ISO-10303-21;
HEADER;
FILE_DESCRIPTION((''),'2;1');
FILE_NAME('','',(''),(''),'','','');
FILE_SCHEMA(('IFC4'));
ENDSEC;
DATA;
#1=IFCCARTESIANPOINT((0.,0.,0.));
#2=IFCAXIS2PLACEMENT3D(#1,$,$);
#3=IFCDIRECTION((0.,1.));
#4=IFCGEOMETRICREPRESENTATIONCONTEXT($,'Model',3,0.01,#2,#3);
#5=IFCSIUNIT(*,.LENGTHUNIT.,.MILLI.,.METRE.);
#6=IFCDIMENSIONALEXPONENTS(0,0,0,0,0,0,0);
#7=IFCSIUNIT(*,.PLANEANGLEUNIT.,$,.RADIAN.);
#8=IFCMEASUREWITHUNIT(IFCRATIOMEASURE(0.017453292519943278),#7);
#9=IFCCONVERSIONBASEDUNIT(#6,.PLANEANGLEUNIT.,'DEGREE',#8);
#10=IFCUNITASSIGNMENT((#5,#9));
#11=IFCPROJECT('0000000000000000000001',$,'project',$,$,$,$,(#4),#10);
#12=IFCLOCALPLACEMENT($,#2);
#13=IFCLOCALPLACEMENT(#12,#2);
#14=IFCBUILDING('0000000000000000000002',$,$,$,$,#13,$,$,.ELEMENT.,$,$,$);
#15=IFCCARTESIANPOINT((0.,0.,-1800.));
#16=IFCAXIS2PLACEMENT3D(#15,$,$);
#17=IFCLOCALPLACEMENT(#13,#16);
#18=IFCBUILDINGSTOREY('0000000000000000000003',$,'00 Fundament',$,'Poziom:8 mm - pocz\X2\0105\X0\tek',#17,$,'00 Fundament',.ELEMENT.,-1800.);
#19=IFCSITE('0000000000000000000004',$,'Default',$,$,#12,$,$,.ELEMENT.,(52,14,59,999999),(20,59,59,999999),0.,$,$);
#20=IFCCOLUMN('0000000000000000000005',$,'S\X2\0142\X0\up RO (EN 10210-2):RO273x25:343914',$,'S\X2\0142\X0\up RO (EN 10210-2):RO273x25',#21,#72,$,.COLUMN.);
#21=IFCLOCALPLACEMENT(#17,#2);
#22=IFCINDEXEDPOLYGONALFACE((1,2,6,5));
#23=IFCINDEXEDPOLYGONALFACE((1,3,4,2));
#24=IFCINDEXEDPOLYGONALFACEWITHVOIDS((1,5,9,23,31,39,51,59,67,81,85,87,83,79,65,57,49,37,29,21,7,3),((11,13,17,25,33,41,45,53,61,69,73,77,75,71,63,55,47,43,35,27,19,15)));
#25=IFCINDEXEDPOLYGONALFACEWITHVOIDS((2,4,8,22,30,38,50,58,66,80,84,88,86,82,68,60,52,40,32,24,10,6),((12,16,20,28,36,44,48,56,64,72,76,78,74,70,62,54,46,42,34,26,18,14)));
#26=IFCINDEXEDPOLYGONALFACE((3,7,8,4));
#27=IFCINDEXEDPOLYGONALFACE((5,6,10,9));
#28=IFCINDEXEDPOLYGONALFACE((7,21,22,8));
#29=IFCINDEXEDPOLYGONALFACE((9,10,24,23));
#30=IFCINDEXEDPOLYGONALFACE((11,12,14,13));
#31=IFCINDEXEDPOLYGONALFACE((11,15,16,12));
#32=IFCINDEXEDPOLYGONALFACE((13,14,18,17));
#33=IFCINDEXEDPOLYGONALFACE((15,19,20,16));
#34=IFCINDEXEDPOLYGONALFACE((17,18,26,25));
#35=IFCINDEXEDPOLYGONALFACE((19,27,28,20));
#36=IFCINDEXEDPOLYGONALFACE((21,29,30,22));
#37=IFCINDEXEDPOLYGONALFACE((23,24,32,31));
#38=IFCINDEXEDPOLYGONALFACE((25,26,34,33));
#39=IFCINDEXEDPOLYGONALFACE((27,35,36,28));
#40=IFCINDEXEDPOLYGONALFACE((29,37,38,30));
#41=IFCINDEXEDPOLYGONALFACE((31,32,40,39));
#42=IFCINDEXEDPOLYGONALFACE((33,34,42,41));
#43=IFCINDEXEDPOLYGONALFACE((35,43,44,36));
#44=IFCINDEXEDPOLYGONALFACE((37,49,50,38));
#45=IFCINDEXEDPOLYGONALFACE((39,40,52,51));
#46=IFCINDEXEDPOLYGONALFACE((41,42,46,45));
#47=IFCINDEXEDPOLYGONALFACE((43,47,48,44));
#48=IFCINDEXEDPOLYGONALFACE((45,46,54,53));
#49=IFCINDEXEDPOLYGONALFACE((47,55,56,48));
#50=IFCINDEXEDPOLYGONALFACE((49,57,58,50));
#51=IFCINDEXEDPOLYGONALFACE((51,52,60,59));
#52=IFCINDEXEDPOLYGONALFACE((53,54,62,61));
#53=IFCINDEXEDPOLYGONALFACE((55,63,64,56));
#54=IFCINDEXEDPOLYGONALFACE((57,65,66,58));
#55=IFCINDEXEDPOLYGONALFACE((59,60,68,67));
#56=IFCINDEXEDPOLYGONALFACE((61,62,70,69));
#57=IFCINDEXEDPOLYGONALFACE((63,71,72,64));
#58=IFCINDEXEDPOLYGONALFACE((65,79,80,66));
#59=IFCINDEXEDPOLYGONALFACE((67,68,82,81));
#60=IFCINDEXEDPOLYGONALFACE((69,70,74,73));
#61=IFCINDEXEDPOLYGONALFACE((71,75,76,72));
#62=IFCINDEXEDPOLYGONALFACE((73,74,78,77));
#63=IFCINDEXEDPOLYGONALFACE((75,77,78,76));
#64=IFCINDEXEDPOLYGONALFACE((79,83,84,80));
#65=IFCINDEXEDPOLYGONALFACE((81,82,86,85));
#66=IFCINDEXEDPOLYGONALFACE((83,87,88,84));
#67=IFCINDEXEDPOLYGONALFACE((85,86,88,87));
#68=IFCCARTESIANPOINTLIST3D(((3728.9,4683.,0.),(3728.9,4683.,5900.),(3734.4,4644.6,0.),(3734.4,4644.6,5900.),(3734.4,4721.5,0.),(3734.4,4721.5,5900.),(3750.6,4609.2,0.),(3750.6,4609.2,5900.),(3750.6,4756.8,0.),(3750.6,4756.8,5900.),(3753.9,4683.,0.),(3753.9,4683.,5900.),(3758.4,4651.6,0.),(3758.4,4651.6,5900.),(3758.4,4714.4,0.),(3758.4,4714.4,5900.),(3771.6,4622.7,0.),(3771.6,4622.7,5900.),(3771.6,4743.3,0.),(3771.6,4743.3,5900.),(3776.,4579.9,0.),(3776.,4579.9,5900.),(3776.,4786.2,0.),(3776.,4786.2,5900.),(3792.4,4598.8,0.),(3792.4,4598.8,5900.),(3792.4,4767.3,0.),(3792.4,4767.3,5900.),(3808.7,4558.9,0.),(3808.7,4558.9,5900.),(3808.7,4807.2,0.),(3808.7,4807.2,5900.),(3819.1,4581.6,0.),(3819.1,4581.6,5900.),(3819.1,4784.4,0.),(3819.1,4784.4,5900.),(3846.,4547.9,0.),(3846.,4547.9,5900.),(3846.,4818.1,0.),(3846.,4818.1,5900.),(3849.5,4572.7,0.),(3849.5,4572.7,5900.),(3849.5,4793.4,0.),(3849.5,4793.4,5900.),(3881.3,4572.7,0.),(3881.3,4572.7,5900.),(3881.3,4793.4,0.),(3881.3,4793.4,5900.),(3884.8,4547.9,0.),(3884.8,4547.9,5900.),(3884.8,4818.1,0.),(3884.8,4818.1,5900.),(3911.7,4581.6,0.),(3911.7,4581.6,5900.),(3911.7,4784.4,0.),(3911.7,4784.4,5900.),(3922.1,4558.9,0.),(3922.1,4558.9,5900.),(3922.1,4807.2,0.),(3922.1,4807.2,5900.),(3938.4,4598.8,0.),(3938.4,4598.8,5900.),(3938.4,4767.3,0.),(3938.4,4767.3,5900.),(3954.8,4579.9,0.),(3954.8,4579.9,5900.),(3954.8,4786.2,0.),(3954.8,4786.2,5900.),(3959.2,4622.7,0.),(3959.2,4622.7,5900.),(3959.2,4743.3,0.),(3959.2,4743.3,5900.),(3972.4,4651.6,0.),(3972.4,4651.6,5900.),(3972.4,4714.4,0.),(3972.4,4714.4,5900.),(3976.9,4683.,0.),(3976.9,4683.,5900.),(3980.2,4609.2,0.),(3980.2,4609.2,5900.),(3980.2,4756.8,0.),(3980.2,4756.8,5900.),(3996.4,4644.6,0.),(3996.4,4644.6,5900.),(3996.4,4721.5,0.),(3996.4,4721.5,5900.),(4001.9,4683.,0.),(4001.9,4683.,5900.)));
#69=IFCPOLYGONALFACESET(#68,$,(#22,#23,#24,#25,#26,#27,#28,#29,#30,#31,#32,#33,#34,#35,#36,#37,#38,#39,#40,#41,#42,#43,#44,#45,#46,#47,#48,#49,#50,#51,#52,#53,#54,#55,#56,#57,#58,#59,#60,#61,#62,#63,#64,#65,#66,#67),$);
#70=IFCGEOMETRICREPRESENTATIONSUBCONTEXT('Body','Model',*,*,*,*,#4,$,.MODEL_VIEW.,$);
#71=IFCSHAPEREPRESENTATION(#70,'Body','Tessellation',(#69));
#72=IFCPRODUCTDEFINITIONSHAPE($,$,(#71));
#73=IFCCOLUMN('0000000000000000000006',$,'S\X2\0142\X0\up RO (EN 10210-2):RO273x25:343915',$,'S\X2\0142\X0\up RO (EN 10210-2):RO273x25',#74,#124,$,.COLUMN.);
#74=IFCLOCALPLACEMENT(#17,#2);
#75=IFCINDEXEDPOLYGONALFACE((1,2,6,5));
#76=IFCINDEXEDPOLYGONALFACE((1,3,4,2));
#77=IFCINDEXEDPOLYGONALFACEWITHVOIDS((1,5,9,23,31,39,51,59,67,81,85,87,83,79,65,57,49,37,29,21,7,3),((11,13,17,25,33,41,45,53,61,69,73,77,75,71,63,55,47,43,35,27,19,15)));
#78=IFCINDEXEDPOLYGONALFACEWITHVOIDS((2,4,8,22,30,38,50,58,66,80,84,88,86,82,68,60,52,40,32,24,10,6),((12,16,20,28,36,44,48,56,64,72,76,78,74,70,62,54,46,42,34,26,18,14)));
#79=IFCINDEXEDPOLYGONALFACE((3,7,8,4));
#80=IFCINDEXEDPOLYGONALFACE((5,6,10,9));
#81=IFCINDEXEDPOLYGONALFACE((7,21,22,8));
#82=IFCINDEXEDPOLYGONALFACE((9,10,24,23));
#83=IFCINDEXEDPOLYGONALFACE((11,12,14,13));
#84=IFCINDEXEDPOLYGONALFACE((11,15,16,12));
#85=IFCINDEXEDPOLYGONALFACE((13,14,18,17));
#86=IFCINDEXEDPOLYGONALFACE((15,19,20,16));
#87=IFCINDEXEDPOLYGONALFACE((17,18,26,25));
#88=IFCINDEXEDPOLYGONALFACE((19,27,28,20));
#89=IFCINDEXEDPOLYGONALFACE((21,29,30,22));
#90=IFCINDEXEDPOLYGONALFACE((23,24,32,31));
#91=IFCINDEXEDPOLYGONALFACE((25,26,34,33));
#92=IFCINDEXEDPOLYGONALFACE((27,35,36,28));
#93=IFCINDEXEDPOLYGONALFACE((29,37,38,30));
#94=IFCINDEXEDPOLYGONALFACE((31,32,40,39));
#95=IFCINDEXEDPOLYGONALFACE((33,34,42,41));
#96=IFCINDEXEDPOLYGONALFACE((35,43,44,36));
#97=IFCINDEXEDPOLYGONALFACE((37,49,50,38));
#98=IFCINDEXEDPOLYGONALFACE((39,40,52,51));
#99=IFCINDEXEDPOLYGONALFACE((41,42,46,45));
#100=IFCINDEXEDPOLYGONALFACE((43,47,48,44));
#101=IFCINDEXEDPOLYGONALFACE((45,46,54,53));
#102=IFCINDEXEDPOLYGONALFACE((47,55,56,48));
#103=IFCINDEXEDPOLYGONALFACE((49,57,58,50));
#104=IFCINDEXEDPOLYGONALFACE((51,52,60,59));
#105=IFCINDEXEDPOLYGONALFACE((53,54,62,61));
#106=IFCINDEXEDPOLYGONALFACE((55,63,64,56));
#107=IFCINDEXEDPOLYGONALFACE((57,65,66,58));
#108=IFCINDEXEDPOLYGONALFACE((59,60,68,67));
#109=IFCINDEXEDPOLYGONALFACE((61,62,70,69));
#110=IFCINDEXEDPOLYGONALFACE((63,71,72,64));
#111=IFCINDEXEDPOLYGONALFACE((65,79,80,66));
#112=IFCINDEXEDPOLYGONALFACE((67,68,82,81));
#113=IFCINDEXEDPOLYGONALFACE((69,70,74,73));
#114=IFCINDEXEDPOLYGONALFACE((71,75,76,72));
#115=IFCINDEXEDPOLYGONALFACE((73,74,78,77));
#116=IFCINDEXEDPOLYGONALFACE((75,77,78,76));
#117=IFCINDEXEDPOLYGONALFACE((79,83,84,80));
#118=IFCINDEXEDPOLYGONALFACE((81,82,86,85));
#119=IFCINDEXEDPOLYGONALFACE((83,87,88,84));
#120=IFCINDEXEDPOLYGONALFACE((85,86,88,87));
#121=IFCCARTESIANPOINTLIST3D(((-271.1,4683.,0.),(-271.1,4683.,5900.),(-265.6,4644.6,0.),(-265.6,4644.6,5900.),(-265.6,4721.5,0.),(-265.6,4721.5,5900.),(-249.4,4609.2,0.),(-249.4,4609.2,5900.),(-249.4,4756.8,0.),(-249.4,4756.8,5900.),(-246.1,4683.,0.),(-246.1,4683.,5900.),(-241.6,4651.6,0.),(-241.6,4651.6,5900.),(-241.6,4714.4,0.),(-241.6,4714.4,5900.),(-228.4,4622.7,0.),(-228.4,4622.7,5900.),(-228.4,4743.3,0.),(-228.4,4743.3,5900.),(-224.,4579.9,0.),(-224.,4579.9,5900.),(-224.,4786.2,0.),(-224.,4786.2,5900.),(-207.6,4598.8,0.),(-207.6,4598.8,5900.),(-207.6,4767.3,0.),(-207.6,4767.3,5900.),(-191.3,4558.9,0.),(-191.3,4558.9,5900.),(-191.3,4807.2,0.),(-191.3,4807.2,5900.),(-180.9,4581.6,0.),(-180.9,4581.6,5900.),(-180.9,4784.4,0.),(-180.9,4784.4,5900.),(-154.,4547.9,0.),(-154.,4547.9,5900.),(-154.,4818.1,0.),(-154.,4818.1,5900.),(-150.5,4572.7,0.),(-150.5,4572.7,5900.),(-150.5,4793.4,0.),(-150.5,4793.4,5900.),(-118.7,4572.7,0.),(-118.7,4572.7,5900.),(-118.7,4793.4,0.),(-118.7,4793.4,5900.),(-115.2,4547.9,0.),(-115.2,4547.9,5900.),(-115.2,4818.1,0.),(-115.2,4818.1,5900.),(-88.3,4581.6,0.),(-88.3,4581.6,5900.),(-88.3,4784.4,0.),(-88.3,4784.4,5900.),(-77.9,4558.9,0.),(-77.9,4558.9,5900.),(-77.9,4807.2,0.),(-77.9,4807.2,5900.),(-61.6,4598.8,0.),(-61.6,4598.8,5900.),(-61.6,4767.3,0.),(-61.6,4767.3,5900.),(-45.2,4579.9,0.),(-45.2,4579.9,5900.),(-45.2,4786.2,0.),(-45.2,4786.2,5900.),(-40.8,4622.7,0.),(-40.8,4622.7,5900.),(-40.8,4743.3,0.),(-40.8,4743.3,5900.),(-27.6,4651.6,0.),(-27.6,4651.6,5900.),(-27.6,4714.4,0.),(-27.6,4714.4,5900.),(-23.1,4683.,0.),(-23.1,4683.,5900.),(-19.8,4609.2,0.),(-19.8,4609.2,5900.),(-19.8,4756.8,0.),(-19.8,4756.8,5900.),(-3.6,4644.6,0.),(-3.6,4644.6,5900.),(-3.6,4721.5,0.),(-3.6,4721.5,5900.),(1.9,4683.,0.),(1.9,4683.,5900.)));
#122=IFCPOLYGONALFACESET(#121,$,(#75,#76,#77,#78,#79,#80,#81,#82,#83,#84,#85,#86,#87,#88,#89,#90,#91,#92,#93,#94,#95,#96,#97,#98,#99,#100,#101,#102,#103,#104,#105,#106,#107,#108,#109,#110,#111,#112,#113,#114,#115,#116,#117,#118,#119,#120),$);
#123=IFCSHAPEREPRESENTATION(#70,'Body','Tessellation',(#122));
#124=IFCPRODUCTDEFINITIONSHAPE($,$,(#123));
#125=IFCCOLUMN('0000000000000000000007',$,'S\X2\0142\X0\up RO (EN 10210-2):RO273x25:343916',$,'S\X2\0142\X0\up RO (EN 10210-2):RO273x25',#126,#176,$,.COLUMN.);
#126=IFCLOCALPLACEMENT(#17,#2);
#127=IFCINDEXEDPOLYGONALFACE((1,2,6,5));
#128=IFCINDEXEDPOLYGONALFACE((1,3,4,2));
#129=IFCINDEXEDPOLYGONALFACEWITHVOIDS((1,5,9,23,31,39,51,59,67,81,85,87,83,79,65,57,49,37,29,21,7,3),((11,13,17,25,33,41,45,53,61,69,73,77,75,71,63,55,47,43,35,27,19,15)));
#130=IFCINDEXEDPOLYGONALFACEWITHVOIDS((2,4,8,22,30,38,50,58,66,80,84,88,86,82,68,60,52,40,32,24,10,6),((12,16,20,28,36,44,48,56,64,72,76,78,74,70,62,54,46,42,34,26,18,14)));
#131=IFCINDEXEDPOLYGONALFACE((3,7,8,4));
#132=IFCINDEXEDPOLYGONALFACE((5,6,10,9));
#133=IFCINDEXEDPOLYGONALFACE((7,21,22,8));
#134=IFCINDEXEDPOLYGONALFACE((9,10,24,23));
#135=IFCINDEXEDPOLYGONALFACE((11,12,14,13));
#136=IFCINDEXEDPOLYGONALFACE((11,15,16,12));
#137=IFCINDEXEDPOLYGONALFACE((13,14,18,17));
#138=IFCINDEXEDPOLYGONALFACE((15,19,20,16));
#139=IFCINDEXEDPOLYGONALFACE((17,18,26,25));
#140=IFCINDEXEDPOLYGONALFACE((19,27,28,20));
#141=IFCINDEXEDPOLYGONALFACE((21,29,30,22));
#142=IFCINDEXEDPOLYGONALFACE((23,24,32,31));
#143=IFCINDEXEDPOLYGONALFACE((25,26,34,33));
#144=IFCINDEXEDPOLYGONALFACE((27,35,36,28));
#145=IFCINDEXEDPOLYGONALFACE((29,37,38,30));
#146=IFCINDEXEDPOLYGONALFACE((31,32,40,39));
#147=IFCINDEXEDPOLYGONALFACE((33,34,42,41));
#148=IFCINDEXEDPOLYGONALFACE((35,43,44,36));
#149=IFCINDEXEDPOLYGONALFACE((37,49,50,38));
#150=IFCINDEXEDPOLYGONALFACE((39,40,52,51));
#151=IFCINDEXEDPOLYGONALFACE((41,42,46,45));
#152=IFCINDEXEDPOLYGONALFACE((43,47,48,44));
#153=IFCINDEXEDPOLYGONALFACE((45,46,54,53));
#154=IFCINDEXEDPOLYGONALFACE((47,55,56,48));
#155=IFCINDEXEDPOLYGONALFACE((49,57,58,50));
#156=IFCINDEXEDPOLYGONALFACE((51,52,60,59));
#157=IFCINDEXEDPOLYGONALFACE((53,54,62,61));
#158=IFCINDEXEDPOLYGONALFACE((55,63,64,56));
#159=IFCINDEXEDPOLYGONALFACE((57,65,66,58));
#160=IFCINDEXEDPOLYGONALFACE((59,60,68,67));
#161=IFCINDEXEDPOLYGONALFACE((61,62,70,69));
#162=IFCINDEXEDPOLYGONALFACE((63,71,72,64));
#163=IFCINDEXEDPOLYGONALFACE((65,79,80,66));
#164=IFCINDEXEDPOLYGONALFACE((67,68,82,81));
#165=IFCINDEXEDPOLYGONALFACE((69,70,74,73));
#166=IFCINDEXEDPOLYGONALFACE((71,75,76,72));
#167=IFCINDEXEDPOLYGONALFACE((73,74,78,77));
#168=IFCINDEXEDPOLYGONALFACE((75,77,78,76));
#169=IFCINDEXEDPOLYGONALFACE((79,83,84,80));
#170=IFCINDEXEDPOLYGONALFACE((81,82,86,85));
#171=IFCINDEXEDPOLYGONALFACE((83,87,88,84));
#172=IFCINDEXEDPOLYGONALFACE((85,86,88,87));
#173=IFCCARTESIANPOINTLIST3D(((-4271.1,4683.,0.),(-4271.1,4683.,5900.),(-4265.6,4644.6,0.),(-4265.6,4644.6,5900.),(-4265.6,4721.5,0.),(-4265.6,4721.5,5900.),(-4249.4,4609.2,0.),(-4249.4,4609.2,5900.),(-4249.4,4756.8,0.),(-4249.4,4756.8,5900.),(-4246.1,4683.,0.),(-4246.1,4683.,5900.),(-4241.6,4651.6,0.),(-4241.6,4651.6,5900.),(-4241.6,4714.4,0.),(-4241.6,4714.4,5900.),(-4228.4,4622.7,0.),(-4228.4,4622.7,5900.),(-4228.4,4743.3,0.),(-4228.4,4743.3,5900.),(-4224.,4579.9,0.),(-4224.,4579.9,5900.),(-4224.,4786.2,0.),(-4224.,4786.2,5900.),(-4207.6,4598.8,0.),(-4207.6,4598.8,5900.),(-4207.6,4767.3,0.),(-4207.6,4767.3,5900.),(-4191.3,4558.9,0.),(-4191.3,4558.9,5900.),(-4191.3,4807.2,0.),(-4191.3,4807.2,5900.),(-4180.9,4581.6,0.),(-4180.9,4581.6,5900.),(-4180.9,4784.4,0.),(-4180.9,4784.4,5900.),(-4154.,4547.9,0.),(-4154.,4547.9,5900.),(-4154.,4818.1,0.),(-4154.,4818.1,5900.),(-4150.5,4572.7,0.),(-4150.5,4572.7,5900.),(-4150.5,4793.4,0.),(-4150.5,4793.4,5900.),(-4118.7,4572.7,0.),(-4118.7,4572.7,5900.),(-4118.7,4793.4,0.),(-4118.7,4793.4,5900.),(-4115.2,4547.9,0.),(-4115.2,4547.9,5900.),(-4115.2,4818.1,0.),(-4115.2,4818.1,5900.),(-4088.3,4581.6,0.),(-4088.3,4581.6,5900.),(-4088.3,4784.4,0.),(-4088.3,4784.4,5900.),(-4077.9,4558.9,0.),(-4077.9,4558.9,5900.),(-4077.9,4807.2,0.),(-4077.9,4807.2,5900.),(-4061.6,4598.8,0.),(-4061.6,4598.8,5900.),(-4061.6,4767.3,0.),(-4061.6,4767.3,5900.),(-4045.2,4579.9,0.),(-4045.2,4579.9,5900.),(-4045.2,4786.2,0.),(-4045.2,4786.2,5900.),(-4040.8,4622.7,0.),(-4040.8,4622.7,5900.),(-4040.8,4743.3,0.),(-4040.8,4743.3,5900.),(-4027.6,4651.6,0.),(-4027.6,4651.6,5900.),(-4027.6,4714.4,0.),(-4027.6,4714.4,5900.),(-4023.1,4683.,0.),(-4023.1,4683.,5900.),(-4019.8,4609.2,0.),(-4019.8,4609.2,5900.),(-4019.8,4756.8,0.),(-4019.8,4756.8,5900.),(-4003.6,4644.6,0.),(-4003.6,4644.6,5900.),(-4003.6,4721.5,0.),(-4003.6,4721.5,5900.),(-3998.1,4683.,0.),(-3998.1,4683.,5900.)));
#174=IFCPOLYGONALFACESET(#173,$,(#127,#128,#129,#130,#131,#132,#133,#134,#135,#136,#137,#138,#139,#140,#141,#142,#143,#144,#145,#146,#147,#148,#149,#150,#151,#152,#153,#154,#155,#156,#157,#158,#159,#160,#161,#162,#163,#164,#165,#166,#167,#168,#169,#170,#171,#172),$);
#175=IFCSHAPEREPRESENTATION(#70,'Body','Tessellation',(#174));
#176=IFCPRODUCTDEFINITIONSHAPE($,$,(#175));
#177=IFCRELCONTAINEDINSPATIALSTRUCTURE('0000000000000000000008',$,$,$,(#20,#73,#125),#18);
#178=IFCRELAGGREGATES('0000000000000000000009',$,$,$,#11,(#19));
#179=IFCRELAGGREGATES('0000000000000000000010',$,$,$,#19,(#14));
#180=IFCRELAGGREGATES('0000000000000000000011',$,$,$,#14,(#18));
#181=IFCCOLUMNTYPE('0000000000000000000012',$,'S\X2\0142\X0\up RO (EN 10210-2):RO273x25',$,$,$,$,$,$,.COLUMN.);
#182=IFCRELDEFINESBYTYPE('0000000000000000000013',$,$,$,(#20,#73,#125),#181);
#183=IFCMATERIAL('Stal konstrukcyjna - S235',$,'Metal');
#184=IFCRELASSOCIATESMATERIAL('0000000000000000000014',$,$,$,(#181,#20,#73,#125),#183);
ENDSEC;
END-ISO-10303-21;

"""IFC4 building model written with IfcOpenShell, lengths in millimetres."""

from ifc_helpers import new_model, entity, si_unit, converted_unit, direction, frame, origin, place, context, subcontext, project, spatial, arc, indexed_curve, outline, extrude, source, transform, mapped, material, type_object, type_shapes, element, save


model = new_model("IFC4")

# Units and contexts
model_context = context("Model", 3, precision=0.01, world=origin(), true_north=direction((0.0, 1.0)))
body_context = subcontext(model_context, "Body", "Model", "MODEL_VIEW")
ifc_project = project(units=[si_unit("LENGTHUNIT", "METRE", prefix="MILLI"), converted_unit("PLANEANGLEUNIT", "DEGREE", entity("IfcRatioMeasure", 0.017453292519943278), si_unit("PLANEANGLEUNIT", "RADIAN"), dimensions=[0, 0, 0, 0, 0, 0, 0])], contexts=[model_context])

# Site, building, storey
site_placement = place(None, origin())
site = spatial("IfcSite", under=ifc_project, at=site_placement, Name="Default", CompositionType="ELEMENT", RefLatitude=(52, 14, 59, 999999), RefLongitude=(20, 59, 59, 999999), RefElevation=0.0)
building_placement = place(site_placement, origin())
building = spatial("IfcBuilding", under=site, at=building_placement, CompositionType="ELEMENT")
storey_placement = place(building_placement, frame((0.0, 0.0, -1800.0)))
storey = spatial("IfcBuildingStorey", under=building, at=storey_placement, Name="00 Fundament", ObjectType="Poziom:8 mm - początek", LongName="00 Fundament", CompositionType="ELEMENT", Elevation=-1800.0)

# Columns
ifc_material_1 = material(Name="Stal konstrukcyjna - S235", Category="Metal")
column_type = type_object("IfcColumnType", Name="Słup RO (EN 10210-2):RO273x25", PredefinedType="COLUMN", material=ifc_material_1)
shared_shape = source(origin(), body_context, "Body", "SweptSolid", [
    extrude(outline(indexed_curve([(-136.5, 0.0), (0.0, -136.5), (136.5, 0.0), (0.0, 136.5)], segments=[arc(1, 2, 3), arc(3, 4, 1)], self_intersect=False), holes=[indexed_curve([(-111.5, 0.0), (0.0, 111.5), (111.5, 0.0), (0.0, -111.5)], segments=[arc(1, 2, 3), arc(3, 4, 1)], self_intersect=False)]), frame((0.0, 0.0, -1800.0)), (0.0, 0.0, 1.0), 5900.0),
])
type_shapes(column_type, [shared_shape])
for number, where, name in (
    (1, (3865.4, 4683.0, 1800.0), "Słup RO (EN 10210-2):RO273x25:343914"),
    (2, (-134.6, 4683.0, 1800.0), "Słup RO (EN 10210-2):RO273x25:343915"),
    (3, (-4134.6, 4683.0, 1800.0), "Słup RO (EN 10210-2):RO273x25:343916"),
):
    element("IfcColumn", number, at=place(storey_placement, frame(where)), inside=storey, type_object=column_type, material=ifc_material_1, Name=name, ObjectType="Słup RO (EN 10210-2):RO273x25", PredefinedType="COLUMN", context=body_context, shape_type="MappedRepresentation", body=[
        mapped(shared_shape, transform((0.0, 0.0, 0.0), scale=1.0)),
    ])

save(model, "model.ifc")
